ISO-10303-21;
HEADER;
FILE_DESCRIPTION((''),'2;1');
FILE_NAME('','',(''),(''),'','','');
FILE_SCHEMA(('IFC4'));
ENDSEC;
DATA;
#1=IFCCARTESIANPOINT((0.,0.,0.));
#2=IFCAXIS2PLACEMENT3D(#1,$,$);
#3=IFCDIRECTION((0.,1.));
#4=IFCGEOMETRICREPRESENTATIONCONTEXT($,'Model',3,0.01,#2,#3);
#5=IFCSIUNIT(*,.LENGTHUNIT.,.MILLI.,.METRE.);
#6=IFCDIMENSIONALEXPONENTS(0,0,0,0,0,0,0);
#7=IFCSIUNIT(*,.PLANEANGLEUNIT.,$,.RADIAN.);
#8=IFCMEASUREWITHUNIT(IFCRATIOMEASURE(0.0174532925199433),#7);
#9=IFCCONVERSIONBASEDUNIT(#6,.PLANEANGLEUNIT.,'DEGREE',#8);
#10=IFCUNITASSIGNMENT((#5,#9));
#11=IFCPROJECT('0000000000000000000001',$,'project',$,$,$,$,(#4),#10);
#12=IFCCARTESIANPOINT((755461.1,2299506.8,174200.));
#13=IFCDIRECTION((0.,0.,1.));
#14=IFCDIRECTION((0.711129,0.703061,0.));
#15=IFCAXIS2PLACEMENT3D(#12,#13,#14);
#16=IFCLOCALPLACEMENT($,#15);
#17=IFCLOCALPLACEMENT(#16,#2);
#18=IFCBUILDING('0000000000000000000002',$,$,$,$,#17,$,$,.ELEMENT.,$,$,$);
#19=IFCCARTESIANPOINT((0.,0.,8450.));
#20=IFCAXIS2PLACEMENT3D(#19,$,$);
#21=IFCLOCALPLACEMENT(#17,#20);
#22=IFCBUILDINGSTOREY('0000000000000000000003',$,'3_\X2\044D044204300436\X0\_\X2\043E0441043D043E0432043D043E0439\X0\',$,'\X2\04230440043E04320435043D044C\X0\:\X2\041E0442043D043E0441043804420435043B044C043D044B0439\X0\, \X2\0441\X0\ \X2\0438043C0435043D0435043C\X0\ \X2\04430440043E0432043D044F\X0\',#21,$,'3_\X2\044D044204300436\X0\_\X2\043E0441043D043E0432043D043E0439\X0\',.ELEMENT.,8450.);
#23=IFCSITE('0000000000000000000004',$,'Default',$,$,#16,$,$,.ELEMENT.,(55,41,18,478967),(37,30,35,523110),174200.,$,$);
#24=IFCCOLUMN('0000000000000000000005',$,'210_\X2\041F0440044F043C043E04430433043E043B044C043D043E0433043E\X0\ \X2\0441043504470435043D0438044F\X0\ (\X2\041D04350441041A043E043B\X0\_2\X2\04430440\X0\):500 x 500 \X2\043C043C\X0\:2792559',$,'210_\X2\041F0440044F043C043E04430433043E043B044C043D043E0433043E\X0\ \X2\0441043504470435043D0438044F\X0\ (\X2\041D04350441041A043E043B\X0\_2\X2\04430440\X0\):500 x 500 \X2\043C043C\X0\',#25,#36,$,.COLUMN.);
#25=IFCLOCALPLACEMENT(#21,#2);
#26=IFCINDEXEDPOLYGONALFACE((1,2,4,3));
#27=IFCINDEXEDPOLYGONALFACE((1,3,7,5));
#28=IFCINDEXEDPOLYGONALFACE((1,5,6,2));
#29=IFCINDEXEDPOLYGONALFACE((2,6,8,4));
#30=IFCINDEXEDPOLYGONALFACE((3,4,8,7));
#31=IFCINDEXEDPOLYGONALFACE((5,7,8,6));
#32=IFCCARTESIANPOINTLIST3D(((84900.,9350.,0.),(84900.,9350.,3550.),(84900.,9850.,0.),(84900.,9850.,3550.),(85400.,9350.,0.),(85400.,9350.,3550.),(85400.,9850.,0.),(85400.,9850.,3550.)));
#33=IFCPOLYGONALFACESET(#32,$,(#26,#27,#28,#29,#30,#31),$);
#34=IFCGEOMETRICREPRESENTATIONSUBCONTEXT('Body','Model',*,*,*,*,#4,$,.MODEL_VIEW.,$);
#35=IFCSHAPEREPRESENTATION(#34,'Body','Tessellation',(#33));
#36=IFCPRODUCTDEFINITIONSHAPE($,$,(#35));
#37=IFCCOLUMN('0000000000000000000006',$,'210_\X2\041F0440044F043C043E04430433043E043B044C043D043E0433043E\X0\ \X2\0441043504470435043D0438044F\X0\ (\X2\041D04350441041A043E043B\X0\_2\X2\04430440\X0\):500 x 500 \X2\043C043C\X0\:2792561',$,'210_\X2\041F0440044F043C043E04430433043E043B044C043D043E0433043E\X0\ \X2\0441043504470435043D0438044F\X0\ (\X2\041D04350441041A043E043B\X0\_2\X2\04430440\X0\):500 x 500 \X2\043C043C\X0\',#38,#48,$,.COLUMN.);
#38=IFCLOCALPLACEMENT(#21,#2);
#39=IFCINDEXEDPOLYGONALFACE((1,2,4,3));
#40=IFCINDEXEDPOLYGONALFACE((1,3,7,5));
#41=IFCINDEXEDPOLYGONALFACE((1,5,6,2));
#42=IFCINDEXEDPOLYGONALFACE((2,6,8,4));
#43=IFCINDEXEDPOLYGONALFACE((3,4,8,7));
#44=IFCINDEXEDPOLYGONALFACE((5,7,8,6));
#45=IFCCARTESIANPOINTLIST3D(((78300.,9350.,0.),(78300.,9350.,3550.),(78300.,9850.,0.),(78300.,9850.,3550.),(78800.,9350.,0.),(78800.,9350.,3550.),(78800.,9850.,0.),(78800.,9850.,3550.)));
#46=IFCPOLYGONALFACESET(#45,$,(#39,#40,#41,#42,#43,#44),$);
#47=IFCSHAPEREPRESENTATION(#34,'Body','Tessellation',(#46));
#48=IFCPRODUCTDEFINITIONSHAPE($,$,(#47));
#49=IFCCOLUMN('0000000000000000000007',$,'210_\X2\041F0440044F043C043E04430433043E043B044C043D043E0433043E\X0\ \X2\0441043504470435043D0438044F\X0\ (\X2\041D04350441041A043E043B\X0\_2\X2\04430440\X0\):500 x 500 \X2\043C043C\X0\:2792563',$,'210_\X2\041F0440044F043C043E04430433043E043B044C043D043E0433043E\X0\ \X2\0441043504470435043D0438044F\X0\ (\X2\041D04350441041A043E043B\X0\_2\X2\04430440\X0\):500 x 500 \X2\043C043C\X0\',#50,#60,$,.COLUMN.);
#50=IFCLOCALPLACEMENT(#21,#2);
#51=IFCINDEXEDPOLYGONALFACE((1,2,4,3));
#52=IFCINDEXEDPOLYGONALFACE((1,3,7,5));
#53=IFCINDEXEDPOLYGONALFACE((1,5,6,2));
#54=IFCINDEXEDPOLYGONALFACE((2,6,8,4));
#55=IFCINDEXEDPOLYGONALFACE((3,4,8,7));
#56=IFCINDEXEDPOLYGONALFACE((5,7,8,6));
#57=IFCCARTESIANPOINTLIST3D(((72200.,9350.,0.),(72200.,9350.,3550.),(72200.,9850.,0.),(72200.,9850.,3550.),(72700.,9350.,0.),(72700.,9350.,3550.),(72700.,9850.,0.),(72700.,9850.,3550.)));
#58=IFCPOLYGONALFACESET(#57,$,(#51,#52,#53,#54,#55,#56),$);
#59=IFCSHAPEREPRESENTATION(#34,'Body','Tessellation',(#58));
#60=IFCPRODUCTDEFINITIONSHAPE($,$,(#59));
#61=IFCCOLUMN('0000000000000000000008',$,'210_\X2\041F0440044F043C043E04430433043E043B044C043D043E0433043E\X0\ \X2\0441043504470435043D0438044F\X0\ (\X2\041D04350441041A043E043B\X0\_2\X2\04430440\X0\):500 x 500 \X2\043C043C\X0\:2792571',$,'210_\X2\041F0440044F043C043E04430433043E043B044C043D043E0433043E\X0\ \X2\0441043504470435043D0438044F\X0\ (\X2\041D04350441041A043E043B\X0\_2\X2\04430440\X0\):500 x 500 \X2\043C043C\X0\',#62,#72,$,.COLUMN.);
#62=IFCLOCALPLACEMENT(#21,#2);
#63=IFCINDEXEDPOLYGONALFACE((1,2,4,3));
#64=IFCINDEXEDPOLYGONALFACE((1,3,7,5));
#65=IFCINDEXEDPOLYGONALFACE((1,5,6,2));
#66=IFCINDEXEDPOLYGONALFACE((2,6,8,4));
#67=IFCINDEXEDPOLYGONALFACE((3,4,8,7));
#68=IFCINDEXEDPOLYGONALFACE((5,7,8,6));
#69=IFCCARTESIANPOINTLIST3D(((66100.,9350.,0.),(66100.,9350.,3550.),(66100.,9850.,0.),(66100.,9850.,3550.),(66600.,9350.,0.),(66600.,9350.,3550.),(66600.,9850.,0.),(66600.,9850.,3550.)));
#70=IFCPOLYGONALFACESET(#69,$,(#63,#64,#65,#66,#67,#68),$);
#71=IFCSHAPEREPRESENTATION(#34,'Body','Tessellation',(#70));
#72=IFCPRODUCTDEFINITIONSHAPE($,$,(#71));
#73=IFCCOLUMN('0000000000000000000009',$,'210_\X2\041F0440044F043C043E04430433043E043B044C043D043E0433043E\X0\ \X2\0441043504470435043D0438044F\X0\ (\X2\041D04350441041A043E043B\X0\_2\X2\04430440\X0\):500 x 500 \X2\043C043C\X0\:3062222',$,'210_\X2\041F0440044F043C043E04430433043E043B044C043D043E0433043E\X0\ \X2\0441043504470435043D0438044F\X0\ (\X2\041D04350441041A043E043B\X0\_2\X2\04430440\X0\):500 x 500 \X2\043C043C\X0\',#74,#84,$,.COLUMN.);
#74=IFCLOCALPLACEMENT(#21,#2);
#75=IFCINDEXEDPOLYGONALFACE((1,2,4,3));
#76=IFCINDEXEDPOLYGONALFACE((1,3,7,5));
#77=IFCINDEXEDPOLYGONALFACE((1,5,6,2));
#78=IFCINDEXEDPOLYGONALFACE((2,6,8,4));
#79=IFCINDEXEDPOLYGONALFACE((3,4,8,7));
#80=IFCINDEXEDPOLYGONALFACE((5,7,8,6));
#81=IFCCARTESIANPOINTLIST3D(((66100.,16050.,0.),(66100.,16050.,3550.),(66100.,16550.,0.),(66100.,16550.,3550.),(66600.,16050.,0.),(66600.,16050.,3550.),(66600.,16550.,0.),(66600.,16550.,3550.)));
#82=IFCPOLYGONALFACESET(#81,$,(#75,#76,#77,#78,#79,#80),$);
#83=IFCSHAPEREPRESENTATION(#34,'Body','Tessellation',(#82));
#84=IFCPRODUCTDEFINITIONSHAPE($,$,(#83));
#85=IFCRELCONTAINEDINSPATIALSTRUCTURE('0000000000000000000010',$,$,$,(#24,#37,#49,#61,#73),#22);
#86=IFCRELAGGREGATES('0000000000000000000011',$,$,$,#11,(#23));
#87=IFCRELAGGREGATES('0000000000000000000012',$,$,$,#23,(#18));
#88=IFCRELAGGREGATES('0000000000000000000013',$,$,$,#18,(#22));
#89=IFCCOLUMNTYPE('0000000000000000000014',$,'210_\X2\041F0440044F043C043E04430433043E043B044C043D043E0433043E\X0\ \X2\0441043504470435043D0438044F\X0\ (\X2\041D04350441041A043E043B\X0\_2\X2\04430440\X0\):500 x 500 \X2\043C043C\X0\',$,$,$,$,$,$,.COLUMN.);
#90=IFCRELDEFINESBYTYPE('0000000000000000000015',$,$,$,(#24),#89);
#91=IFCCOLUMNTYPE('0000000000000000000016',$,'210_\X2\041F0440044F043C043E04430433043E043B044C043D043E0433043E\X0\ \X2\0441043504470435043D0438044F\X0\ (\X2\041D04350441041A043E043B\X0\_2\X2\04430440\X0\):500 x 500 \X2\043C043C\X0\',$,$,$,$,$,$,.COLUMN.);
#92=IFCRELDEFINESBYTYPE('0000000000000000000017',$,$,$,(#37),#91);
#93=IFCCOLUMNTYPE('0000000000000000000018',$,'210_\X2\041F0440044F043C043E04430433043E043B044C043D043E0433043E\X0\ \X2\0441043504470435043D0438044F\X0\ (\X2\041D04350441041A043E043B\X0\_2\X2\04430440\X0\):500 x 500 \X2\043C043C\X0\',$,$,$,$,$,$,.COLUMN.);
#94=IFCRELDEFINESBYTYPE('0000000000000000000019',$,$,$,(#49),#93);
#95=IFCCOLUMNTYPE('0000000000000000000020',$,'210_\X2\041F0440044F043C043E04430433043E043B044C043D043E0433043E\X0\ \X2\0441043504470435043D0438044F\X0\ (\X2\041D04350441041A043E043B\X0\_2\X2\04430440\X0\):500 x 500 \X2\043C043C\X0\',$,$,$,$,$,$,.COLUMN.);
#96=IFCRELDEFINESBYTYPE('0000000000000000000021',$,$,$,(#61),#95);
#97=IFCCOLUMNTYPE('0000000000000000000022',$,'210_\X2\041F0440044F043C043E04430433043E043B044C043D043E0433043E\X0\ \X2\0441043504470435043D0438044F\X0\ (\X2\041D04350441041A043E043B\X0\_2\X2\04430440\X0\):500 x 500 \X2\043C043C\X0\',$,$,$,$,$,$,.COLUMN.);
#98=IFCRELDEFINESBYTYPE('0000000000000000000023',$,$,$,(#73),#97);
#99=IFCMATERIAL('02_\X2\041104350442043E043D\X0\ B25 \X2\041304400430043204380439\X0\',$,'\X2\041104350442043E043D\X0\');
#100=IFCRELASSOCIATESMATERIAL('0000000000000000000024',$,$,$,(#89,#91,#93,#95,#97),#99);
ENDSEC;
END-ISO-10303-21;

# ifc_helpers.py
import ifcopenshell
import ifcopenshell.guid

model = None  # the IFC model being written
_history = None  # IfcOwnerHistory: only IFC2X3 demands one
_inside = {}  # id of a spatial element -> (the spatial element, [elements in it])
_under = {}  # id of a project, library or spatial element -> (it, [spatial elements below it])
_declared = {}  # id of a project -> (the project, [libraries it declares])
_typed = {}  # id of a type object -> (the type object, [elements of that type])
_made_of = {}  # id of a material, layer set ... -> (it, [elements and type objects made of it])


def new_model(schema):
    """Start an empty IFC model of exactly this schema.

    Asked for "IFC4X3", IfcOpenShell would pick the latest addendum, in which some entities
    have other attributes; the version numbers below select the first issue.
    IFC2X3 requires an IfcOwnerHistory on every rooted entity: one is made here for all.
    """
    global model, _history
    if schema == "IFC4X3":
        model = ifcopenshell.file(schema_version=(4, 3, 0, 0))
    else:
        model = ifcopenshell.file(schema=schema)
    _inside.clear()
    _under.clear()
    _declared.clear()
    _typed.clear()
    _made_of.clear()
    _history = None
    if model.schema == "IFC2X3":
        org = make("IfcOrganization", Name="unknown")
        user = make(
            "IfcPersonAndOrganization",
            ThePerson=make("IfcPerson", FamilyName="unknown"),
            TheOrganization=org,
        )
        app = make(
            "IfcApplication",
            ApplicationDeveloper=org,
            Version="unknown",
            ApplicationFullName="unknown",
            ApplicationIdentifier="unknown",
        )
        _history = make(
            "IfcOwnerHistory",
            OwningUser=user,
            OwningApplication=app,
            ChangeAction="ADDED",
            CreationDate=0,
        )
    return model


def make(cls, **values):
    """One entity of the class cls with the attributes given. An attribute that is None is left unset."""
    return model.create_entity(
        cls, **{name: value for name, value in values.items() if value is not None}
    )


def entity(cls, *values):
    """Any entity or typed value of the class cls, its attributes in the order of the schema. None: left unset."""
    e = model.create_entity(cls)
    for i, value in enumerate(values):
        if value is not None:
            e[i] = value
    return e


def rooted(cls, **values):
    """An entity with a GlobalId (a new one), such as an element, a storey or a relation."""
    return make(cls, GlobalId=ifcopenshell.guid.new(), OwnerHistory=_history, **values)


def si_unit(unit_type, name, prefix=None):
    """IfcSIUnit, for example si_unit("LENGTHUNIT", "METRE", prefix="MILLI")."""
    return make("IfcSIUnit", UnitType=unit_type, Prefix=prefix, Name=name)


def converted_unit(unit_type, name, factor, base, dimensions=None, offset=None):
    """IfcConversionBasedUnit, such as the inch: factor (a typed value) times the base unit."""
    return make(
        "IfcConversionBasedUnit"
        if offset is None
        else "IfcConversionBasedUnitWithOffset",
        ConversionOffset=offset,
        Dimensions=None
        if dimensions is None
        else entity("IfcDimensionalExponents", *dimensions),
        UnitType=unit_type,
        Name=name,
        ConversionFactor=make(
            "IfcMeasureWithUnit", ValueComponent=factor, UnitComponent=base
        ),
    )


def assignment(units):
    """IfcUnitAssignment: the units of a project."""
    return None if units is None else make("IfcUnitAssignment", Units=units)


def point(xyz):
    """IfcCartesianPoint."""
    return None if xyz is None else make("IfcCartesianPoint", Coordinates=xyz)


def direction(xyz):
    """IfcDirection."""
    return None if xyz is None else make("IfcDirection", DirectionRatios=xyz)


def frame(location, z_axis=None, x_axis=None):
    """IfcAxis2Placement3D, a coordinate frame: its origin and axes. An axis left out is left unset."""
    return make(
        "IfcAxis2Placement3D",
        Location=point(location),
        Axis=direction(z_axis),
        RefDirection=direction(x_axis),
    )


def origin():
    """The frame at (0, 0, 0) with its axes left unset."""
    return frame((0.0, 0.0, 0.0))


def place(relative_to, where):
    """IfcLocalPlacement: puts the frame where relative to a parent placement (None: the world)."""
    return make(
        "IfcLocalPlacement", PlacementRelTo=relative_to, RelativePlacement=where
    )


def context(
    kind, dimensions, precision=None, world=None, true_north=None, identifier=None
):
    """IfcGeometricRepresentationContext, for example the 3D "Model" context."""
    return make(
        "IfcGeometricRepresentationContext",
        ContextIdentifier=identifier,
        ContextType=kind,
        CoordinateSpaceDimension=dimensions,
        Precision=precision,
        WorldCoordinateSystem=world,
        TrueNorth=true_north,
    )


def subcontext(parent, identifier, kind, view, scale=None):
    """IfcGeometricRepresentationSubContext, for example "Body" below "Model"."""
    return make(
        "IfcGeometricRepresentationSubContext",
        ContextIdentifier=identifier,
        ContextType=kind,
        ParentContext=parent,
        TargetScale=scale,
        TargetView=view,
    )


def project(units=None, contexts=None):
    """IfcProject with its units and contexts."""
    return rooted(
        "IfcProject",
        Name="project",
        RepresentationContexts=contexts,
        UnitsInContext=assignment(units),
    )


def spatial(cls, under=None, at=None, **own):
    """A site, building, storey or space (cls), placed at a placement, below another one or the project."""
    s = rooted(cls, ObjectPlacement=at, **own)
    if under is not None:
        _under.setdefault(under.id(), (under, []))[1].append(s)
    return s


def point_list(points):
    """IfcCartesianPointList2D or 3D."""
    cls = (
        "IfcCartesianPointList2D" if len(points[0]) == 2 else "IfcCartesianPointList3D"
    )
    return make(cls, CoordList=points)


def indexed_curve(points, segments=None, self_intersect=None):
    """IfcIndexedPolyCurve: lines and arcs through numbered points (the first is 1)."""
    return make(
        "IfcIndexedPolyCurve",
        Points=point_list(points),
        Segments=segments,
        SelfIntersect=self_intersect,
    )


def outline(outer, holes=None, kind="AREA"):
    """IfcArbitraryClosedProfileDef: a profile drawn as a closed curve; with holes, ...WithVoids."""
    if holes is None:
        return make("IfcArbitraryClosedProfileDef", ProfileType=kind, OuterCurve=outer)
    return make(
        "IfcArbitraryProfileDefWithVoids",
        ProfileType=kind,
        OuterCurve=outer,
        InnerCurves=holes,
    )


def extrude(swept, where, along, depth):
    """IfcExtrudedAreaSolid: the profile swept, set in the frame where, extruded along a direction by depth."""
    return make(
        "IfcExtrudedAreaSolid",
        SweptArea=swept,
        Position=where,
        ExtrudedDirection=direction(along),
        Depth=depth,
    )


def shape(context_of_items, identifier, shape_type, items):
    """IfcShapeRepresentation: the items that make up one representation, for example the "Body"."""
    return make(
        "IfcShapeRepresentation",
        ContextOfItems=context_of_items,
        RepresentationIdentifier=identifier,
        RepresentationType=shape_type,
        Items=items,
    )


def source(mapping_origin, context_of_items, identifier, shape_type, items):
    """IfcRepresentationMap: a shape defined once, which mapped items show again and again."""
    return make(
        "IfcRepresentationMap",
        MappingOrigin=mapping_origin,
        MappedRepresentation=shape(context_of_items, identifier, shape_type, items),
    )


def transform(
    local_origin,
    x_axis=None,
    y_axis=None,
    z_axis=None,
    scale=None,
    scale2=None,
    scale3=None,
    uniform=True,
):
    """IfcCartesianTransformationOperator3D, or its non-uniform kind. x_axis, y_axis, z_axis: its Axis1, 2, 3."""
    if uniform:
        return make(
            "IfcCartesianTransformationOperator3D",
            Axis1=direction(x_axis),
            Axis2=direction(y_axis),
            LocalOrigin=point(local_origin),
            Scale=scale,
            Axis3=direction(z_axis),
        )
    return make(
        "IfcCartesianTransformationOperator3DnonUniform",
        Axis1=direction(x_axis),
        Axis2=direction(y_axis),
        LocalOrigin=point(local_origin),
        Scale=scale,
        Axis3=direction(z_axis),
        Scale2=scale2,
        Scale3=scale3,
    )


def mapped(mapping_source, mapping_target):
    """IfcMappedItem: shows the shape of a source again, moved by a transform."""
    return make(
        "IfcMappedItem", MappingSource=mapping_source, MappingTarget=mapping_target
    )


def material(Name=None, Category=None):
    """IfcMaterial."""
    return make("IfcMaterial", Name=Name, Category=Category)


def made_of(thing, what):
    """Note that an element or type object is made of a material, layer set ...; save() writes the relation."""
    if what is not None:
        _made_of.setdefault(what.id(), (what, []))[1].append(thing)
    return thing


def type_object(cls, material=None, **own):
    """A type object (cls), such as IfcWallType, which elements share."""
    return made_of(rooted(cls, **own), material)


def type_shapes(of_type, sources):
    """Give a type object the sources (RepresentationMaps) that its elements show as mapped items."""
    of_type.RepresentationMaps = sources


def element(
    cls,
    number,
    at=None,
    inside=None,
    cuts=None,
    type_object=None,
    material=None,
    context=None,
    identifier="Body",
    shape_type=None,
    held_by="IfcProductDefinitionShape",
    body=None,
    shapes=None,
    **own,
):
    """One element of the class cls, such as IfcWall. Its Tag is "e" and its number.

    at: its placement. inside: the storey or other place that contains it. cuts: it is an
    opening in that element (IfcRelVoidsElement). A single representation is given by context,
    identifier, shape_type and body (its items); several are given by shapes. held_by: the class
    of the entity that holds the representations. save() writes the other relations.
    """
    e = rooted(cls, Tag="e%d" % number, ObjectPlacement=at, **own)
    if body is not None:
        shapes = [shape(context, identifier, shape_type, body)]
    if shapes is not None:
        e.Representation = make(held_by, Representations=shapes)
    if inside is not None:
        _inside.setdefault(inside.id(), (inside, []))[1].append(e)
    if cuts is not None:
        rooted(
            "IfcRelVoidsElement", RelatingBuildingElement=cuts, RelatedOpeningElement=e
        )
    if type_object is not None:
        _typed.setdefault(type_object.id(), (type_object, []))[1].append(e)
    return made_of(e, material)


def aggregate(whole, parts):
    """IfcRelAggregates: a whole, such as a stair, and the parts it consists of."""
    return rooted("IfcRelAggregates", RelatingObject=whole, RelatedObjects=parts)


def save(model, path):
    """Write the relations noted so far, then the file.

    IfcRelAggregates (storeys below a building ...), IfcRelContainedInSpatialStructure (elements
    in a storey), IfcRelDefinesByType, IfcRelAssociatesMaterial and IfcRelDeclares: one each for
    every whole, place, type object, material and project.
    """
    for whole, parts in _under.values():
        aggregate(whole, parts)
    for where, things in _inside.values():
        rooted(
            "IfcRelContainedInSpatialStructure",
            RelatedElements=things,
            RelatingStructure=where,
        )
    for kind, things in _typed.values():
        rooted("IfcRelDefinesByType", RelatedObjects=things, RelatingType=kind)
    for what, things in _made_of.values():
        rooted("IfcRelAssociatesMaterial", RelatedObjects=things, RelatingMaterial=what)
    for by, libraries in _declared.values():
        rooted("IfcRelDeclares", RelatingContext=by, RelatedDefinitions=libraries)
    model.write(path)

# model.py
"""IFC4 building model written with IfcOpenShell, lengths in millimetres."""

from ifc_helpers import new_model, entity, si_unit, converted_unit, direction, frame, origin, place, context, subcontext, project, spatial, indexed_curve, outline, extrude, source, transform, mapped, material, type_object, type_shapes, element, save


model = new_model("IFC4")

# Units and contexts
model_context = context("Model", 3, precision=0.01, world=origin(), true_north=direction((0.0, 1.0)))
body_context = subcontext(model_context, "Body", "Model", "MODEL_VIEW")
ifc_project = project(units=[si_unit("LENGTHUNIT", "METRE", prefix="MILLI"), converted_unit("PLANEANGLEUNIT", "DEGREE", entity("IfcRatioMeasure", 0.0174532925199433), si_unit("PLANEANGLEUNIT", "RADIAN"), dimensions=[0, 0, 0, 0, 0, 0, 0])], contexts=[model_context])

# Site, building, storey
site_placement = place(None, frame((755461.1, 2299506.8, 174200.0), z_axis=(0.0, 0.0, 1.0), x_axis=(0.711129, 0.703061, 0.0)))
site = spatial("IfcSite", under=ifc_project, at=site_placement, Name="Default", CompositionType="ELEMENT", RefLatitude=(55, 41, 18, 478967), RefLongitude=(37, 30, 35, 523110), RefElevation=174200.0)
building_placement = place(site_placement, origin())
building = spatial("IfcBuilding", under=site, at=building_placement, CompositionType="ELEMENT")
storey_placement = place(building_placement, frame((0.0, 0.0, 8450.0)))
storey = spatial("IfcBuildingStorey", under=building, at=storey_placement, Name="3_этаж_основной", ObjectType="Уровень:Относительный, с именем уровня", LongName="3_этаж_основной", CompositionType="ELEMENT", Elevation=8450.0)

# Columns
ifc_material_1 = material(Name="02_Бетон B25 Гравий", Category="Бетон")
column_type_1 = type_object("IfcColumnType", Name="210_Прямоугольного сечения (НесКол_2ур):500 x 500 мм", PredefinedType="COLUMN", material=ifc_material_1)
shared_shape_1 = source(origin(), body_context, "Body", "SweptSolid", [
    extrude(outline(indexed_curve([(-250.0, -250.0), (250.0, -250.0), (250.0, 250.0), (-250.0, 250.0), (-250.0, -250.0)], self_intersect=False)), frame((85150.0, 9600.0, 8450.0), z_axis=(0.0, 0.0, 1.0), x_axis=(0.0, -1.0, 0.0)), (0.0, 0.0, 1.0), 3550.0),
])
type_shapes(column_type_1, [shared_shape_1])
column_1_placement = place(storey_placement, frame((0.0, 0.0, -8450.0)))
element("IfcColumn", 1, at=column_1_placement, inside=storey, type_object=column_type_1, Name="210_Прямоугольного сечения (НесКол_2ур):500 x 500 мм:2792559", ObjectType="210_Прямоугольного сечения (НесКол_2ур):500 x 500 мм", PredefinedType="COLUMN", context=body_context, shape_type="MappedRepresentation", body=[
    mapped(shared_shape_1, transform((0.0, 0.0, 0.0), scale=1.0)),
])
column_type_2 = type_object("IfcColumnType", Name="210_Прямоугольного сечения (НесКол_2ур):500 x 500 мм", PredefinedType="COLUMN", material=ifc_material_1)
shared_shape_2 = source(origin(), body_context, "Body", "SweptSolid", [
    extrude(outline(indexed_curve([(-250.0, -250.0), (250.0, -250.0), (250.0, 250.0), (-250.0, 250.0), (-250.0, -250.0)], self_intersect=False)), frame((78550.0, 9600.0, 8450.0), z_axis=(0.0, 0.0, 1.0), x_axis=(0.0, -1.0, 0.0)), (0.0, 0.0, 1.0), 3550.0),
])
type_shapes(column_type_2, [shared_shape_2])
column_2_placement = place(storey_placement, frame((0.0, 0.0, -8450.0)))
element("IfcColumn", 2, at=column_2_placement, inside=storey, type_object=column_type_2, Name="210_Прямоугольного сечения (НесКол_2ур):500 x 500 мм:2792561", ObjectType="210_Прямоугольного сечения (НесКол_2ур):500 x 500 мм", PredefinedType="COLUMN", context=body_context, shape_type="MappedRepresentation", body=[
    mapped(shared_shape_2, transform((0.0, 0.0, 0.0), scale=1.0)),
])
column_type_3 = type_object("IfcColumnType", Name="210_Прямоугольного сечения (НесКол_2ур):500 x 500 мм", PredefinedType="COLUMN", material=ifc_material_1)
shared_shape_3 = source(origin(), body_context, "Body", "SweptSolid", [
    extrude(outline(indexed_curve([(-250.0, -250.0), (250.0, -250.0), (250.0, 250.0), (-250.0, 250.0), (-250.0, -250.0)], self_intersect=False)), frame((72450.0, 9600.0, 8450.0), z_axis=(0.0, 0.0, 1.0), x_axis=(0.0, -1.0, 0.0)), (0.0, 0.0, 1.0), 3550.0),
])
type_shapes(column_type_3, [shared_shape_3])
column_3_placement = place(storey_placement, frame((0.0, 0.0, -8450.0)))
element("IfcColumn", 3, at=column_3_placement, inside=storey, type_object=column_type_3, Name="210_Прямоугольного сечения (НесКол_2ур):500 x 500 мм:2792563", ObjectType="210_Прямоугольного сечения (НесКол_2ур):500 x 500 мм", PredefinedType="COLUMN", context=body_context, shape_type="MappedRepresentation", body=[
    mapped(shared_shape_3, transform((0.0, 0.0, 0.0), scale=1.0)),
])
column_type_4 = type_object("IfcColumnType", Name="210_Прямоугольного сечения (НесКол_2ур):500 x 500 мм", PredefinedType="COLUMN", material=ifc_material_1)
shared_shape_4 = source(origin(), body_context, "Body", "SweptSolid", [
    extrude(outline(indexed_curve([(-250.0, -250.0), (250.0, -250.0), (250.0, 250.0), (-250.0, 250.0), (-250.0, -250.0)], self_intersect=False)), frame((66350.0, 9600.0, 8450.0), z_axis=(0.0, 0.0, 1.0), x_axis=(0.0, -1.0, 0.0)), (0.0, 0.0, 1.0), 3550.0),
])
type_shapes(column_type_4, [shared_shape_4])
column_4_placement = place(storey_placement, frame((0.0, 0.0, -8450.0)))
element("IfcColumn", 4, at=column_4_placement, inside=storey, type_object=column_type_4, Name="210_Прямоугольного сечения (НесКол_2ур):500 x 500 мм:2792571", ObjectType="210_Прямоугольного сечения (НесКол_2ур):500 x 500 мм", PredefinedType="COLUMN", context=body_context, shape_type="MappedRepresentation", body=[
    mapped(shared_shape_4, transform((0.0, 0.0, 0.0), scale=1.0)),
])
column_type_5 = type_object("IfcColumnType", Name="210_Прямоугольного сечения (НесКол_2ур):500 x 500 мм", PredefinedType="COLUMN", material=ifc_material_1)
shared_shape_5 = source(origin(), body_context, "Body", "SweptSolid", [
    extrude(outline(indexed_curve([(-250.0, -250.0), (250.0, -250.0), (250.0, 250.0), (-250.0, 250.0), (-250.0, -250.0)], self_intersect=False)), frame((66350.0, 16300.0, 8450.0), z_axis=(0.0, 0.0, 1.0), x_axis=(0.0, -1.0, 0.0)), (0.0, 0.0, 1.0), 3550.0),
])
type_shapes(column_type_5, [shared_shape_5])
column_5_placement = place(storey_placement, frame((0.0, 0.0, -8450.0)))
element("IfcColumn", 5, at=column_5_placement, inside=storey, type_object=column_type_5, Name="210_Прямоугольного сечения (НесКол_2ур):500 x 500 мм:3062222", ObjectType="210_Прямоугольного сечения (НесКол_2ур):500 x 500 мм", PredefinedType="COLUMN", context=body_context, shape_type="MappedRepresentation", body=[
    mapped(shared_shape_5, transform((0.0, 0.0, 0.0), scale=1.0)),
])

save(model, "model.ifc")
